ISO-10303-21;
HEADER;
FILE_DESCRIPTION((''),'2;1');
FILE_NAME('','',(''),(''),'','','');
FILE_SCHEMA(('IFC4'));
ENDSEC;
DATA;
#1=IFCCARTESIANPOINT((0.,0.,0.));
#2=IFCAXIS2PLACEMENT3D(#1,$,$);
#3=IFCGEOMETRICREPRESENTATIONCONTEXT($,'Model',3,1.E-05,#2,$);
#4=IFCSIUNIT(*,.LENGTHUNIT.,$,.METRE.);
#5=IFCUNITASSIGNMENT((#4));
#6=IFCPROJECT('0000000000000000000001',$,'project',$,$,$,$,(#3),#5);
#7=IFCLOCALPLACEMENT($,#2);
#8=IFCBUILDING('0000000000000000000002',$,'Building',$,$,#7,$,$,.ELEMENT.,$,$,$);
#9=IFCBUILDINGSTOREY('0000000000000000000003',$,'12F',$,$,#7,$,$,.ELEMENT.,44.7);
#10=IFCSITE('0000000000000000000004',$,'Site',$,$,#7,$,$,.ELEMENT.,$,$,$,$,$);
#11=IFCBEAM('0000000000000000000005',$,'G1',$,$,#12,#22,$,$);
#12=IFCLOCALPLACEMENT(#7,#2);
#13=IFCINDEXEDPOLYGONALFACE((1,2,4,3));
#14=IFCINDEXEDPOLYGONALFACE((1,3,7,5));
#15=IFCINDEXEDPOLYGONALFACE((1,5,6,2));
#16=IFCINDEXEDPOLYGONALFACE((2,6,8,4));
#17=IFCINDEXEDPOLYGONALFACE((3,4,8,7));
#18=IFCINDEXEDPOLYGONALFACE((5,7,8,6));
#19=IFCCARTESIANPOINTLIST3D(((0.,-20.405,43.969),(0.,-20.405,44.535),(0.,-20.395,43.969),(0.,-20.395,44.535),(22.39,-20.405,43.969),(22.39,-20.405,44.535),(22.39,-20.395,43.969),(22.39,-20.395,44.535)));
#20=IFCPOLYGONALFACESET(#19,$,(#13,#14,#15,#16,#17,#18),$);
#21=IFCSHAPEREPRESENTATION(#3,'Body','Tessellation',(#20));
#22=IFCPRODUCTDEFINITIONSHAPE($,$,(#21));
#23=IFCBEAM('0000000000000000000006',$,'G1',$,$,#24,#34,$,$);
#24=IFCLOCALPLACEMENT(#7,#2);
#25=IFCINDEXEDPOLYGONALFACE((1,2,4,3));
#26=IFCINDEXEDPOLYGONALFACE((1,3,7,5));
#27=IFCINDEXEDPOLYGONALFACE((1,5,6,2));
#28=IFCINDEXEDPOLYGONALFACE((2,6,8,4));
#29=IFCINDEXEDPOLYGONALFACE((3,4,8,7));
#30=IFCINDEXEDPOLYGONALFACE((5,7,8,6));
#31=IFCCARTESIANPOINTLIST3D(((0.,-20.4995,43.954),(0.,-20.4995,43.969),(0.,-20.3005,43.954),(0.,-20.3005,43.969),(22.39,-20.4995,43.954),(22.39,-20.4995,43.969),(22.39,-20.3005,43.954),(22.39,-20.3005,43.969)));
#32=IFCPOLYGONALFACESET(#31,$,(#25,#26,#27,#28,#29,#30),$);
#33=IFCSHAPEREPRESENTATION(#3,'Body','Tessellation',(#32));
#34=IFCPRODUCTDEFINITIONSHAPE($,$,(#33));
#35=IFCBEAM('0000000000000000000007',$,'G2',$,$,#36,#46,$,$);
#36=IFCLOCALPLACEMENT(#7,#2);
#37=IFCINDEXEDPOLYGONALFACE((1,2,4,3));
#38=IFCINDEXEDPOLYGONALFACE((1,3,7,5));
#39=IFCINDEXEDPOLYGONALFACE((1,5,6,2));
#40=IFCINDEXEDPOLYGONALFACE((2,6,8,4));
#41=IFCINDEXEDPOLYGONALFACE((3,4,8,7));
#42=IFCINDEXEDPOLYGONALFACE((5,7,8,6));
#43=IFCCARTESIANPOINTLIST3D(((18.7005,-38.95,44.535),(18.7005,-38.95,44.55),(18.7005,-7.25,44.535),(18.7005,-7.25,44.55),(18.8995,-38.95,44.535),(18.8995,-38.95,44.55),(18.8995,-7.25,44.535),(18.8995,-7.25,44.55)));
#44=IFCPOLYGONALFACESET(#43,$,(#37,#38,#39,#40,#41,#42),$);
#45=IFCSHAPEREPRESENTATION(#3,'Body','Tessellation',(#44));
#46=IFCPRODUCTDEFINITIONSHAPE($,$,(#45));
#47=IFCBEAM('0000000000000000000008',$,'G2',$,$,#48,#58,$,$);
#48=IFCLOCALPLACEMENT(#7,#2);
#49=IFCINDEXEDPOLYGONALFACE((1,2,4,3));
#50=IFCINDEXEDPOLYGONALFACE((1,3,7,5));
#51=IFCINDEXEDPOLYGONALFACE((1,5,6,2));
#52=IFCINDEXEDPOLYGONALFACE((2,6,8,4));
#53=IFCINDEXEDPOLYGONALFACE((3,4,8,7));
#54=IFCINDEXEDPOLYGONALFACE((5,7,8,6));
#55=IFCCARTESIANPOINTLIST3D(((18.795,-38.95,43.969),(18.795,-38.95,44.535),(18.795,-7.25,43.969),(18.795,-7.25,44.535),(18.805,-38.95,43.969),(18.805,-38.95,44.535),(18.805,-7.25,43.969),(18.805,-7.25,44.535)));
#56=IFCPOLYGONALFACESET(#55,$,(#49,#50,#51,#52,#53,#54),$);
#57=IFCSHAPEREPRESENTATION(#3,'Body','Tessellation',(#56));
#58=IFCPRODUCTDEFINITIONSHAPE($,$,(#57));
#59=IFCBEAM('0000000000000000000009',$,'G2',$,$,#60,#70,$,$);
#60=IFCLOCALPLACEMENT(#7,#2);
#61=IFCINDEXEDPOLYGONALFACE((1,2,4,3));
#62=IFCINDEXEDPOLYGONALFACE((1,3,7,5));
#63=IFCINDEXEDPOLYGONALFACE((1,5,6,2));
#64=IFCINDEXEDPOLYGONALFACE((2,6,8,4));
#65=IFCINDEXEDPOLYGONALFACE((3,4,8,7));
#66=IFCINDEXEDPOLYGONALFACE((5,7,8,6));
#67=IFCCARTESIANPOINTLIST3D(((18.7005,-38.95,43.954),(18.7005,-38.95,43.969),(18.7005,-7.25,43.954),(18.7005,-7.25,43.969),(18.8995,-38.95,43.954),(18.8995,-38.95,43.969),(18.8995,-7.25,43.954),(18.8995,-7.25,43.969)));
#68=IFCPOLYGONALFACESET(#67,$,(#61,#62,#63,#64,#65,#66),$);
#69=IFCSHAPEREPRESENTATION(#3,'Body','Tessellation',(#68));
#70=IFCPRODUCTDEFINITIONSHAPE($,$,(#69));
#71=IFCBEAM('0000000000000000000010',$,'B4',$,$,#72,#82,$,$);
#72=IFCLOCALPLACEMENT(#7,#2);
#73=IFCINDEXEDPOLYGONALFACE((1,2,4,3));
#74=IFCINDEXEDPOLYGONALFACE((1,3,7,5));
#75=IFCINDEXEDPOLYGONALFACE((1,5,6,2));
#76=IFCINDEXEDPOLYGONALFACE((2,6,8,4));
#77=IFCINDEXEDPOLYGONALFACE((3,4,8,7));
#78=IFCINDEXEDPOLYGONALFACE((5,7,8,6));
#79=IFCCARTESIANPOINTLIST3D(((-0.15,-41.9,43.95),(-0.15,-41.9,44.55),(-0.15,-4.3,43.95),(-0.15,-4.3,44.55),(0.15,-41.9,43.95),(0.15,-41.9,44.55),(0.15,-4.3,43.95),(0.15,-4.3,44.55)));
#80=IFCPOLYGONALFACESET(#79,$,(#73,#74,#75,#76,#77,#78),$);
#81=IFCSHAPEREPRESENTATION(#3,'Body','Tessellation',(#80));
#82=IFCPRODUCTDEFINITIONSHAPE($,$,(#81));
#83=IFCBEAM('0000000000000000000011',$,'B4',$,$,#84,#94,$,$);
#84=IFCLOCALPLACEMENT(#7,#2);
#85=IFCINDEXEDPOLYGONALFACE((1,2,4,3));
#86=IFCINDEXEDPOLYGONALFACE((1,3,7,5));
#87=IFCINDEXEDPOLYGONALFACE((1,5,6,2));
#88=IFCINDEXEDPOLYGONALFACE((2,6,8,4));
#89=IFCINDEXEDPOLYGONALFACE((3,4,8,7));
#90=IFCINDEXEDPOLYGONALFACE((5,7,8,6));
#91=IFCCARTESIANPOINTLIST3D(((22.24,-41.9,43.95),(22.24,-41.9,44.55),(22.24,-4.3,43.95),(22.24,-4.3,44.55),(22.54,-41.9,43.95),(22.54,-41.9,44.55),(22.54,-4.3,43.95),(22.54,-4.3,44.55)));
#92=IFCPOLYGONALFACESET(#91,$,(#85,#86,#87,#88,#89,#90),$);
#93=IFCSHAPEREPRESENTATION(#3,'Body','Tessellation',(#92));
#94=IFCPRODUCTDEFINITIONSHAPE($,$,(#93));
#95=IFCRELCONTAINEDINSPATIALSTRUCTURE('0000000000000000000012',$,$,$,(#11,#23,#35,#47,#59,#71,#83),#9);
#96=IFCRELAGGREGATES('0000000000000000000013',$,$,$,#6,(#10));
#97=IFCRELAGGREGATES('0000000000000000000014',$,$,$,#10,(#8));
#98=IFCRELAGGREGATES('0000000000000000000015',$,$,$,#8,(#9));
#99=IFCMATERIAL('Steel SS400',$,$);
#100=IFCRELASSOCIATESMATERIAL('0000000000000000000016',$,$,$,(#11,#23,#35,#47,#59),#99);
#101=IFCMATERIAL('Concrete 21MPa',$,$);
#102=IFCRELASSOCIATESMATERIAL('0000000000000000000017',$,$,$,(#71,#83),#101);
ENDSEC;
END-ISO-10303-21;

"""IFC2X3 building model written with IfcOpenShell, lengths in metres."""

from ifc_helpers import new_model, si_unit, frame, origin, origin_2d, place, context, project, spatial, rectangle, extrude, material, element, save


model = new_model("IFC2X3")

# Units and contexts
model_context = context("Model", 3, precision=1e-05, world=origin())
ifc_project = project(units=[si_unit("LENGTHUNIT", "METRE")], contexts=[model_context])

# Site, building, storey
placement = place(None, origin())
site = spatial("IfcSite", under=ifc_project, at=placement, Name="Site", CompositionType="ELEMENT")
building = spatial("IfcBuilding", under=site, at=placement, Name="Building", CompositionType="ELEMENT")
storey = spatial("IfcBuildingStorey", under=building, at=placement, Name="12F", CompositionType="ELEMENT", Elevation=44.7)

# Shared definitions
ifc_material_1 = material(Name="Concrete 21MPa")
ifc_material_2 = material(Name="Steel SS400")

# Beams
beam_1_placement = place(None, frame((11.195, -20.4, 43.969)))
element("IfcBeam", 1, at=beam_1_placement, inside=storey, material=ifc_material_2, Name="G1", context=model_context, shape_type="SweptSolid", body=[
    extrude(rectangle(XDim=22.39, YDim=0.01, at=origin_2d()), origin(), (0.0, 0.0, 1.0), 0.566),
])
beam_2_placement = place(None, frame((11.195, -20.4, 43.954)))
element("IfcBeam", 2, at=beam_2_placement, inside=storey, material=ifc_material_2, Name="G1", context=model_context, shape_type="SweptSolid", body=[
    extrude(rectangle(XDim=22.39, YDim=0.199, at=origin_2d()), origin(), (0.0, 0.0, 1.0), 0.015),
])
beam_3_placement = place(None, frame((18.8, -23.1, 44.535)))
element("IfcBeam", 3, at=beam_3_placement, inside=storey, material=ifc_material_2, Name="G2", context=model_context, shape_type="SweptSolid", body=[
    extrude(rectangle(XDim=0.199, YDim=31.7, at=origin_2d()), origin(), (0.0, 0.0, 1.0), 0.015),
])
beam_4_placement = place(None, frame((18.8, -23.1, 43.969)))
element("IfcBeam", 4, at=beam_4_placement, inside=storey, material=ifc_material_2, Name="G2", context=model_context, shape_type="SweptSolid", body=[
    extrude(rectangle(XDim=0.01, YDim=31.7, at=origin_2d()), origin(), (0.0, 0.0, 1.0), 0.566),
])
beam_5_placement = place(None, frame((18.8, -23.1, 43.954)))
element("IfcBeam", 5, at=beam_5_placement, inside=storey, material=ifc_material_2, Name="G2", context=model_context, shape_type="SweptSolid", body=[
    extrude(rectangle(XDim=0.199, YDim=31.7, at=origin_2d()), origin(), (0.0, 0.0, 1.0), 0.015),
])
for number, where, name in (
    (6, (0.0, -23.1, 43.95), "B4"),
    (7, (22.39, -23.1, 43.95), "B4"),
):
    element("IfcBeam", number, at=place(None, frame(where)), inside=storey, material=ifc_material_1, Name=name, context=model_context, shape_type="SweptSolid", body=[
        extrude(rectangle(XDim=0.3, YDim=37.6, at=origin_2d()), origin(), (0.0, 0.0, 1.0), 0.6),
    ])

save(model, "model.ifc")
